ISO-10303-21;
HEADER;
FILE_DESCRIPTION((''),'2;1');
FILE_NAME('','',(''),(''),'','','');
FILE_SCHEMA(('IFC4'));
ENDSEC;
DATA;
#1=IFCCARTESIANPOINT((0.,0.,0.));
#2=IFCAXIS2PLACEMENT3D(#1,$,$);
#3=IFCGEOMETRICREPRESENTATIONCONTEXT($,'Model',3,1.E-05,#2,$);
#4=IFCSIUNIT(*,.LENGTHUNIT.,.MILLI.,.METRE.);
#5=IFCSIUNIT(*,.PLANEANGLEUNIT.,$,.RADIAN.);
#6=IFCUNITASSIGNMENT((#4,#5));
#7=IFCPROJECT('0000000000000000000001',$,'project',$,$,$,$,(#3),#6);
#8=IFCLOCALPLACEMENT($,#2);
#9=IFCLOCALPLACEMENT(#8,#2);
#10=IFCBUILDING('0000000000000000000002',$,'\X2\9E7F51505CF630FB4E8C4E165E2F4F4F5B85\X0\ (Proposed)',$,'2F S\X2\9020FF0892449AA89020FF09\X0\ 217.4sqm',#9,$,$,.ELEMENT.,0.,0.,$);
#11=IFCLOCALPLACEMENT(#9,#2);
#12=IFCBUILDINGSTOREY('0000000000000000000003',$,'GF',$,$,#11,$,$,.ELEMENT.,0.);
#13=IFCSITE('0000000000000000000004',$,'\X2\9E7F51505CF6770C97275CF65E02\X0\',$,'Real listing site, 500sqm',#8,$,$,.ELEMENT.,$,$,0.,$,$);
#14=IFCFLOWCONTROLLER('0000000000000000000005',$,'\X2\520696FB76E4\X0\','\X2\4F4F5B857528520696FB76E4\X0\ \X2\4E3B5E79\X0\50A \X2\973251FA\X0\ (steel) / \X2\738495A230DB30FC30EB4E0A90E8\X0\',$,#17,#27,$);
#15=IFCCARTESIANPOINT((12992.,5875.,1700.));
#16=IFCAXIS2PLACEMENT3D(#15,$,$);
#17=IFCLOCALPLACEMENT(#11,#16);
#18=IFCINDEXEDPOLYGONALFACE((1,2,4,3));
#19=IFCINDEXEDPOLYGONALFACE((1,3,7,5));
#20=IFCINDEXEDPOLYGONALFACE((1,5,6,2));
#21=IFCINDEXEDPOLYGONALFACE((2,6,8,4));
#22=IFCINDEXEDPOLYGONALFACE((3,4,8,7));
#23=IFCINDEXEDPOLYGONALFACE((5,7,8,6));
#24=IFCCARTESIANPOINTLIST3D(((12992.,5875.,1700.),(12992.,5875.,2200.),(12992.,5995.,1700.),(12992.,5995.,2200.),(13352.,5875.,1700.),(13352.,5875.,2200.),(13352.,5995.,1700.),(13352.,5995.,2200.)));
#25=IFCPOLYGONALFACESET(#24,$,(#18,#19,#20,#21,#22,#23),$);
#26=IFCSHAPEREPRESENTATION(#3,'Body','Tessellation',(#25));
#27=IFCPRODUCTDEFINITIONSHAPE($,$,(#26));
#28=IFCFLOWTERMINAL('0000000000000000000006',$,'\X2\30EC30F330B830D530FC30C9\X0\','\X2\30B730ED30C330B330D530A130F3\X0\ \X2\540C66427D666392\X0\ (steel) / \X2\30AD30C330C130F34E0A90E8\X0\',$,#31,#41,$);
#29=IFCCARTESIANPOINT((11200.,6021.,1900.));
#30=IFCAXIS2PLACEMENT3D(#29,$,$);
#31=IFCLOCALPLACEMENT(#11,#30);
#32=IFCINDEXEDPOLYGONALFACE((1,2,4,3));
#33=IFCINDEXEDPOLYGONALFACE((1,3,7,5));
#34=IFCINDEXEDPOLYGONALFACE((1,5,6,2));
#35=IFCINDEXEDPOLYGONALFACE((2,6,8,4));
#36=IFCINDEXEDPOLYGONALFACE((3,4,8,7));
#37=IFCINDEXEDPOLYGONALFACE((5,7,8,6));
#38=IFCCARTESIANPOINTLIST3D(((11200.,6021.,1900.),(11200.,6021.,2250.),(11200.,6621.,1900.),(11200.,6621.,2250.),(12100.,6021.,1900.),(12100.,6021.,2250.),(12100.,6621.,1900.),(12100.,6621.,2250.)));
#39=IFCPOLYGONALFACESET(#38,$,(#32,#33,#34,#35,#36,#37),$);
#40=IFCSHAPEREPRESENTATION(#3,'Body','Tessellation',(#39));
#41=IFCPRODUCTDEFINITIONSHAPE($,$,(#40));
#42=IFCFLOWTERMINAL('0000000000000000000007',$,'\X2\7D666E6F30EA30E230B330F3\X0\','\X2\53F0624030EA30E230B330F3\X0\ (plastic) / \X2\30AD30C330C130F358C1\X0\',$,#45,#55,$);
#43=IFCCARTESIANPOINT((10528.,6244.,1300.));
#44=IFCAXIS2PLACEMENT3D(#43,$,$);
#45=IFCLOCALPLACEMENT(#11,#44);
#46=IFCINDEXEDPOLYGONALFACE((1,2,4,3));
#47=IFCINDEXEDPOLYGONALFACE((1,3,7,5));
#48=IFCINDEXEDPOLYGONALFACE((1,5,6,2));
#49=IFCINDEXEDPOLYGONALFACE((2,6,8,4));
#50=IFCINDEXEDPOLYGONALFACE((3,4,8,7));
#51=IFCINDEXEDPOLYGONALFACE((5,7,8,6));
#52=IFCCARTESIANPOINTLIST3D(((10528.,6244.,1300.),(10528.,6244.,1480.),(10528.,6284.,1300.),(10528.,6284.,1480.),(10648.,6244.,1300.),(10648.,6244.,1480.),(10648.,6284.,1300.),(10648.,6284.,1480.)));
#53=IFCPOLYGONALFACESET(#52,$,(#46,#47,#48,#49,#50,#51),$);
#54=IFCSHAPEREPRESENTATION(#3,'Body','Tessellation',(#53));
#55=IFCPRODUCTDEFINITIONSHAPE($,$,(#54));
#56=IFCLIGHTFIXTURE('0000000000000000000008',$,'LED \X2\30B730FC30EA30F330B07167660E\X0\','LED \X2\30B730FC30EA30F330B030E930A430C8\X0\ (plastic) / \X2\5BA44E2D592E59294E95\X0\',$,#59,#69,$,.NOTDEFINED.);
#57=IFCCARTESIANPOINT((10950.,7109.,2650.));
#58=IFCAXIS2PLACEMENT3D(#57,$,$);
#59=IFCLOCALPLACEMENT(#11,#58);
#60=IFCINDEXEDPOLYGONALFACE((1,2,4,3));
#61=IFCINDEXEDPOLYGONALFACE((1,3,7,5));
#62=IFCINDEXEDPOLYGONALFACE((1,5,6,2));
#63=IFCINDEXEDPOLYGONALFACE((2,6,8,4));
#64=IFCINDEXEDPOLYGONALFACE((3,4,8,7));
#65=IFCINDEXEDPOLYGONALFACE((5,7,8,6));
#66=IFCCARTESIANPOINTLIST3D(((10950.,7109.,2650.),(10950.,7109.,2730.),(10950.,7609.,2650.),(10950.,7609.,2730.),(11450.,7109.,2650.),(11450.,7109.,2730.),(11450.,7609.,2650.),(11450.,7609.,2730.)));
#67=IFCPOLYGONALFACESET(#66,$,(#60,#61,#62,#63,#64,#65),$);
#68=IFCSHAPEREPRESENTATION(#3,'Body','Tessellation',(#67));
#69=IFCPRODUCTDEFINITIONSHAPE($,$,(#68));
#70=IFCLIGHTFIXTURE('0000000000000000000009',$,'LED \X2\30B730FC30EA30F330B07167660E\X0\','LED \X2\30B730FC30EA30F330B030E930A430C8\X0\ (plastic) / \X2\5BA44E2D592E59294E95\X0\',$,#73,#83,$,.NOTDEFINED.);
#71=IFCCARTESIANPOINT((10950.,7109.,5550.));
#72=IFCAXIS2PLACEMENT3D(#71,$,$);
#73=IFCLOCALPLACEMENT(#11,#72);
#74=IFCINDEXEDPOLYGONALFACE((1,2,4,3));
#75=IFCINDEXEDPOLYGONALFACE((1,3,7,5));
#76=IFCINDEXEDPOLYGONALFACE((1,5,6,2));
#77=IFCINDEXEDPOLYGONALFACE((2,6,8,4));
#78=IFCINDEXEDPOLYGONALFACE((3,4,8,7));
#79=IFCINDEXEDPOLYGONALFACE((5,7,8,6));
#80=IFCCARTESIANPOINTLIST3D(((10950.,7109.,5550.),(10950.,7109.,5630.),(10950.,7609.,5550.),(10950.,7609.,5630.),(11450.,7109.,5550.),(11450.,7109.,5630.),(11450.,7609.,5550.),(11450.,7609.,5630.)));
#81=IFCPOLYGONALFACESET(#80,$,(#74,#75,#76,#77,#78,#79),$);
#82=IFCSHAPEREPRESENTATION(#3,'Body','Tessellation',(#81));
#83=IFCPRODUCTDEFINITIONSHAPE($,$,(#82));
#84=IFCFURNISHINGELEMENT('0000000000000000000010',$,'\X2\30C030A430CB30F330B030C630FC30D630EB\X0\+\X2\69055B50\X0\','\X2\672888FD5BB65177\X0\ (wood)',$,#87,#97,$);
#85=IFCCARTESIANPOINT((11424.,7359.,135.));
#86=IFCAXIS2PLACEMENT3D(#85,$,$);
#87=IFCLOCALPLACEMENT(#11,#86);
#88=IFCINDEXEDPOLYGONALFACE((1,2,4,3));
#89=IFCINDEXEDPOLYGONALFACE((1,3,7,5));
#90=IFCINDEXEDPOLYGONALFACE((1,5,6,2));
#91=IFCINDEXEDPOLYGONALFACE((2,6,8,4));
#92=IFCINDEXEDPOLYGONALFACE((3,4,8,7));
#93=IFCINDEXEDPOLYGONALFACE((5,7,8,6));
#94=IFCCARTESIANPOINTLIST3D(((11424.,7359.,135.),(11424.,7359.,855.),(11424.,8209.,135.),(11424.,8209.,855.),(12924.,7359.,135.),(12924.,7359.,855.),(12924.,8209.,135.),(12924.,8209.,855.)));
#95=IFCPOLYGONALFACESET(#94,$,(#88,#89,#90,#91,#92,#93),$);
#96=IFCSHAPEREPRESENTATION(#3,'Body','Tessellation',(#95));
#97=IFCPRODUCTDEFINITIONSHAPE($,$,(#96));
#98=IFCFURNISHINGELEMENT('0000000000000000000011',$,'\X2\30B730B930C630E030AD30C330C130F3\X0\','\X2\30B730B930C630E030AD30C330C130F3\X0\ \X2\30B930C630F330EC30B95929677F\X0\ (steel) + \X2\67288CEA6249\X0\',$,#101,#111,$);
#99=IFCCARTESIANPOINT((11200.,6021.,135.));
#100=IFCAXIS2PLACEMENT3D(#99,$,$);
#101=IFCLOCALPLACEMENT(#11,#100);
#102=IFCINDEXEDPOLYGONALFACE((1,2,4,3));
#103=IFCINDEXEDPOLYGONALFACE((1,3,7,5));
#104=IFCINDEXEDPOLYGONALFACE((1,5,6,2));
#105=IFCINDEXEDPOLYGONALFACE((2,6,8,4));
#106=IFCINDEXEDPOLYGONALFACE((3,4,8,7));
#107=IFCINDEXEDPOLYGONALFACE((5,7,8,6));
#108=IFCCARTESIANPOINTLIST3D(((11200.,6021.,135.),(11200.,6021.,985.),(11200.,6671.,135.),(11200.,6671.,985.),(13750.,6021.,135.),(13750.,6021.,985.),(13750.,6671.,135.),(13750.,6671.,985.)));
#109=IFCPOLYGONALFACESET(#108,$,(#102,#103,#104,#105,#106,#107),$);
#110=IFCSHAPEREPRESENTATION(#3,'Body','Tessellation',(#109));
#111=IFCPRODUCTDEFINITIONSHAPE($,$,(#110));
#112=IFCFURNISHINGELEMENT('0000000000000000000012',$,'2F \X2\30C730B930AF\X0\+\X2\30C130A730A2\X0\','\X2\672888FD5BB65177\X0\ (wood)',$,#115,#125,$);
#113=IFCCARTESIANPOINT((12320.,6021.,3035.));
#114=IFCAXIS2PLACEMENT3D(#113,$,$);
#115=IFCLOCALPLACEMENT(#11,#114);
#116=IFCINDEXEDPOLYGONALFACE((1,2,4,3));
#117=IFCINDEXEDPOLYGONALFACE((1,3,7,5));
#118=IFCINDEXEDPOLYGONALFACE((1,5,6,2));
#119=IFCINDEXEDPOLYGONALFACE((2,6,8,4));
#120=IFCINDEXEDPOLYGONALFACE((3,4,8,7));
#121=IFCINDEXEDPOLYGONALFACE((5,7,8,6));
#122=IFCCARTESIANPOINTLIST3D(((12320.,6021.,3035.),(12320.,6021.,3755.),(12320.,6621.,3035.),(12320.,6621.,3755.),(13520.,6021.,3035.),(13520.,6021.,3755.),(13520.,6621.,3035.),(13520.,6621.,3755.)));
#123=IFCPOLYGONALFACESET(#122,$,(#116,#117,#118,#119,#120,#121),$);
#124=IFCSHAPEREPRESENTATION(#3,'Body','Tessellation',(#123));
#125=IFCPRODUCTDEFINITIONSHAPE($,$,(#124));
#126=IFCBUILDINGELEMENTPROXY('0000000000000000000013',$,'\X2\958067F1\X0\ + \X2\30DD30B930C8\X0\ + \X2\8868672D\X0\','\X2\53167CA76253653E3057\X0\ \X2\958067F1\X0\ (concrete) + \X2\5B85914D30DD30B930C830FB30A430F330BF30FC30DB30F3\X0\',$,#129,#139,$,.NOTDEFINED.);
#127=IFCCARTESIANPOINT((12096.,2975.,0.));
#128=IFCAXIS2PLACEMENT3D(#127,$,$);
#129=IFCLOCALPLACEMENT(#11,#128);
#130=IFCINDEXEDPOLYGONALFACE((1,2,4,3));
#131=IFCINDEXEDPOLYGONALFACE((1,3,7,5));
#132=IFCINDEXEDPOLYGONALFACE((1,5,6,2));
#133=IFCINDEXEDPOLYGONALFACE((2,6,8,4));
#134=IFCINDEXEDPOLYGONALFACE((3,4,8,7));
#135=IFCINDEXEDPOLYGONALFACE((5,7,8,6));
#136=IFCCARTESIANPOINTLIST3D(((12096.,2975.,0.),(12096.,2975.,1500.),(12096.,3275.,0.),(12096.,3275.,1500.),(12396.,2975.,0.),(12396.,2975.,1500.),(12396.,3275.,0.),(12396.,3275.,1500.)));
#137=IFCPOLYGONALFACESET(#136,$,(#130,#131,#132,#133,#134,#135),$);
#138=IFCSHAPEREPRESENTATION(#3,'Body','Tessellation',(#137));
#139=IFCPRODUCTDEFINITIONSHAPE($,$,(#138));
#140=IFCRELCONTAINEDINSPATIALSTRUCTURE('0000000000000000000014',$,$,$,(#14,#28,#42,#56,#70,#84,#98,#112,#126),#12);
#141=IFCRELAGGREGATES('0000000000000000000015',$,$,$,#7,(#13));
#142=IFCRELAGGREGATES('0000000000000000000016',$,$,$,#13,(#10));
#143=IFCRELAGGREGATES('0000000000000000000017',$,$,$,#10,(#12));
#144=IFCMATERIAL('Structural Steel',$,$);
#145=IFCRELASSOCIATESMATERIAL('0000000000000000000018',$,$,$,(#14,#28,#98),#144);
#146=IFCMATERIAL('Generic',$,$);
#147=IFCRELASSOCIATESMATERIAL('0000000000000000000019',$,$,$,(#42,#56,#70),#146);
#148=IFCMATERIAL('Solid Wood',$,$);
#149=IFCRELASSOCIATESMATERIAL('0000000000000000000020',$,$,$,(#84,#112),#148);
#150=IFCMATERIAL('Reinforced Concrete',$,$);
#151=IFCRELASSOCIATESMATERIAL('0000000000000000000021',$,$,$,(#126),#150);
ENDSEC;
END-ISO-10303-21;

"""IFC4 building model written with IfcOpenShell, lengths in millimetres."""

from ifc_helpers import new_model, si_unit, frame, frame_2d, origin, place, context, project, spatial, rectangle, extrude, material, element, save


model = new_model("IFC4")

# Units and contexts
model_context = context("Model", 3, precision=1e-05, world=origin())
ifc_project = project(units=[si_unit("LENGTHUNIT", "METRE", prefix="MILLI"), si_unit("PLANEANGLEUNIT", "RADIAN")], contexts=[model_context])

# Site, building, storey
site_placement = place(None, origin())
site = spatial("IfcSite", under=ifc_project, at=site_placement, Name="鹿児島県霧島市", ObjectType="Real listing site, 500sqm", CompositionType="ELEMENT", RefElevation=0.0)
building_placement = place(site_placement, origin())
building = spatial("IfcBuilding", under=site, at=building_placement, Name="鹿児島・二世帯住宅 (Proposed)", ObjectType="2F S造（鉄骨造） 217.4sqm", CompositionType="ELEMENT", ElevationOfRefHeight=0.0, ElevationOfTerrain=0.0)
storey_placement = place(building_placement, origin())
storey = spatial("IfcBuildingStorey", under=building, at=storey_placement, Name="GF", CompositionType="ELEMENT", Elevation=0.0)

# Shared definitions
ifc_material_1 = material(Name="Solid Wood")

# Shared definitions
ifc_material_2 = material(Name="Structural Steel")

# Shared definitions
ifc_material_3 = material(Name="Reinforced Concrete")

# Flow controller
flow_controller_placement = place(storey_placement, frame((12992.0, 5875.0, 1700.0)))
element("IfcFlowController", 1, at=flow_controller_placement, inside=storey, material=ifc_material_2, Name="分電盤", Description="住宅用分電盤 主幹50A 露出 (steel) / 玄関ホール上部", context=model_context, shape_type="SweptSolid", body=[
    extrude(rectangle(XDim=360.0, YDim=120.0, at=frame_2d((180.0, 60.0))), frame((12992.0, 5875.0, 1700.0)), (0.0, 0.0, 1.0), 500.0),
])

# Flow terminals
flow_terminal_1_placement = place(storey_placement, frame((11200.0, 6021.0, 1900.0)))
element("IfcFlowTerminal", 2, at=flow_terminal_1_placement, inside=storey, material=ifc_material_2, Name="レンジフード", Description="シロッコファン 同時給排 (steel) / キッチン上部", context=model_context, shape_type="SweptSolid", body=[
    extrude(rectangle(XDim=900.0, YDim=600.0, at=frame_2d((450.0, 300.0))), frame((11200.0, 6021.0, 1900.0)), (0.0, 0.0, 1.0), 350.0),
])
ifc_material_4 = material(Name="Generic")
flow_terminal_2_placement = place(storey_placement, frame((10528.0, 6244.0, 1300.0)))
element("IfcFlowTerminal", 3, at=flow_terminal_2_placement, inside=storey, material=ifc_material_4, Name="給湯リモコン", Description="台所リモコン (plastic) / キッチン壁", context=model_context, shape_type="SweptSolid", body=[
    extrude(rectangle(XDim=120.0, YDim=40.0, at=frame_2d((60.0, 20.0))), frame((10528.0, 6244.0, 1300.0)), (0.0, 0.0, 1.0), 180.0),
])

# Light fixtures
light_fixture_1_placement = place(storey_placement, frame((10950.0, 7109.0, 2650.0)))
element("IfcLightFixture", 4, at=light_fixture_1_placement, inside=storey, material=ifc_material_4, Name="LED シーリング照明", Description="LED シーリングライト (plastic) / 室中央天井", PredefinedType="NOTDEFINED", context=model_context, shape_type="SweptSolid", body=[
    extrude(rectangle(XDim=500.0, YDim=500.0, at=frame_2d((250.0, 250.0))), frame((10950.0, 7109.0, 2650.0)), (0.0, 0.0, 1.0), 80.0),
])
light_fixture_2_placement = place(storey_placement, frame((10950.0, 7109.0, 5550.0)))
element("IfcLightFixture", 5, at=light_fixture_2_placement, inside=storey, material=ifc_material_4, Name="LED シーリング照明", Description="LED シーリングライト (plastic) / 室中央天井", PredefinedType="NOTDEFINED", context=model_context, shape_type="SweptSolid", body=[
    extrude(rectangle(XDim=500.0, YDim=500.0, at=frame_2d((250.0, 250.0))), frame((10950.0, 7109.0, 5550.0)), (0.0, 0.0, 1.0), 80.0),
])

# Furnishing elements
furnishing_1_placement = place(storey_placement, frame((11424.0, 7359.0, 135.0)))
element("IfcFurnishingElement", 6, at=furnishing_1_placement, inside=storey, material=ifc_material_1, Name="ダイニングテーブル+椅子", Description="木製家具 (wood)", context=model_context, shape_type="SweptSolid", body=[
    extrude(rectangle(XDim=1500.0, YDim=850.0, at=frame_2d((750.0, 425.0))), frame((11424.0, 7359.0, 135.0)), (0.0, 0.0, 1.0), 720.0),
])
furnishing_2_placement = place(storey_placement, frame((11200.0, 6021.0, 135.0)))
element("IfcFurnishingElement", 7, at=furnishing_2_placement, inside=storey, material=ifc_material_2, Name="システムキッチン", Description="システムキッチン ステンレス天板 (steel) + 木質扉", context=model_context, shape_type="SweptSolid", body=[
    extrude(rectangle(XDim=2550.0, YDim=650.0, at=frame_2d((1275.0, 325.0))), frame((11200.0, 6021.0, 135.0)), (0.0, 0.0, 1.0), 850.0),
])
furnishing_3_placement = place(storey_placement, frame((12320.0, 6021.0, 3035.0)))
element("IfcFurnishingElement", 8, at=furnishing_3_placement, inside=storey, material=ifc_material_1, Name="2F デスク+チェア", Description="木製家具 (wood)", context=model_context, shape_type="SweptSolid", body=[
    extrude(rectangle(XDim=1200.0, YDim=600.0, at=frame_2d((600.0, 300.0))), frame((12320.0, 6021.0, 3035.0)), (0.0, 0.0, 1.0), 720.0),
])

# Building element proxy
proxy_placement = place(storey_placement, frame((12096.0, 2975.0, 0.0)))
element("IfcBuildingElementProxy", 9, at=proxy_placement, inside=storey, material=ifc_material_3, Name="門柱 + ポスト + 表札", Description="化粧打放し 門柱 (concrete) + 宅配ポスト・インターホン", PredefinedType="NOTDEFINED", context=model_context, shape_type="SweptSolid", body=[
    extrude(rectangle(XDim=300.0, YDim=300.0, at=frame_2d((150.0, 150.0))), frame((12096.0, 2975.0, 0.0)), (0.0, 0.0, 1.0), 1500.0),
])

save(model, "model.ifc")
